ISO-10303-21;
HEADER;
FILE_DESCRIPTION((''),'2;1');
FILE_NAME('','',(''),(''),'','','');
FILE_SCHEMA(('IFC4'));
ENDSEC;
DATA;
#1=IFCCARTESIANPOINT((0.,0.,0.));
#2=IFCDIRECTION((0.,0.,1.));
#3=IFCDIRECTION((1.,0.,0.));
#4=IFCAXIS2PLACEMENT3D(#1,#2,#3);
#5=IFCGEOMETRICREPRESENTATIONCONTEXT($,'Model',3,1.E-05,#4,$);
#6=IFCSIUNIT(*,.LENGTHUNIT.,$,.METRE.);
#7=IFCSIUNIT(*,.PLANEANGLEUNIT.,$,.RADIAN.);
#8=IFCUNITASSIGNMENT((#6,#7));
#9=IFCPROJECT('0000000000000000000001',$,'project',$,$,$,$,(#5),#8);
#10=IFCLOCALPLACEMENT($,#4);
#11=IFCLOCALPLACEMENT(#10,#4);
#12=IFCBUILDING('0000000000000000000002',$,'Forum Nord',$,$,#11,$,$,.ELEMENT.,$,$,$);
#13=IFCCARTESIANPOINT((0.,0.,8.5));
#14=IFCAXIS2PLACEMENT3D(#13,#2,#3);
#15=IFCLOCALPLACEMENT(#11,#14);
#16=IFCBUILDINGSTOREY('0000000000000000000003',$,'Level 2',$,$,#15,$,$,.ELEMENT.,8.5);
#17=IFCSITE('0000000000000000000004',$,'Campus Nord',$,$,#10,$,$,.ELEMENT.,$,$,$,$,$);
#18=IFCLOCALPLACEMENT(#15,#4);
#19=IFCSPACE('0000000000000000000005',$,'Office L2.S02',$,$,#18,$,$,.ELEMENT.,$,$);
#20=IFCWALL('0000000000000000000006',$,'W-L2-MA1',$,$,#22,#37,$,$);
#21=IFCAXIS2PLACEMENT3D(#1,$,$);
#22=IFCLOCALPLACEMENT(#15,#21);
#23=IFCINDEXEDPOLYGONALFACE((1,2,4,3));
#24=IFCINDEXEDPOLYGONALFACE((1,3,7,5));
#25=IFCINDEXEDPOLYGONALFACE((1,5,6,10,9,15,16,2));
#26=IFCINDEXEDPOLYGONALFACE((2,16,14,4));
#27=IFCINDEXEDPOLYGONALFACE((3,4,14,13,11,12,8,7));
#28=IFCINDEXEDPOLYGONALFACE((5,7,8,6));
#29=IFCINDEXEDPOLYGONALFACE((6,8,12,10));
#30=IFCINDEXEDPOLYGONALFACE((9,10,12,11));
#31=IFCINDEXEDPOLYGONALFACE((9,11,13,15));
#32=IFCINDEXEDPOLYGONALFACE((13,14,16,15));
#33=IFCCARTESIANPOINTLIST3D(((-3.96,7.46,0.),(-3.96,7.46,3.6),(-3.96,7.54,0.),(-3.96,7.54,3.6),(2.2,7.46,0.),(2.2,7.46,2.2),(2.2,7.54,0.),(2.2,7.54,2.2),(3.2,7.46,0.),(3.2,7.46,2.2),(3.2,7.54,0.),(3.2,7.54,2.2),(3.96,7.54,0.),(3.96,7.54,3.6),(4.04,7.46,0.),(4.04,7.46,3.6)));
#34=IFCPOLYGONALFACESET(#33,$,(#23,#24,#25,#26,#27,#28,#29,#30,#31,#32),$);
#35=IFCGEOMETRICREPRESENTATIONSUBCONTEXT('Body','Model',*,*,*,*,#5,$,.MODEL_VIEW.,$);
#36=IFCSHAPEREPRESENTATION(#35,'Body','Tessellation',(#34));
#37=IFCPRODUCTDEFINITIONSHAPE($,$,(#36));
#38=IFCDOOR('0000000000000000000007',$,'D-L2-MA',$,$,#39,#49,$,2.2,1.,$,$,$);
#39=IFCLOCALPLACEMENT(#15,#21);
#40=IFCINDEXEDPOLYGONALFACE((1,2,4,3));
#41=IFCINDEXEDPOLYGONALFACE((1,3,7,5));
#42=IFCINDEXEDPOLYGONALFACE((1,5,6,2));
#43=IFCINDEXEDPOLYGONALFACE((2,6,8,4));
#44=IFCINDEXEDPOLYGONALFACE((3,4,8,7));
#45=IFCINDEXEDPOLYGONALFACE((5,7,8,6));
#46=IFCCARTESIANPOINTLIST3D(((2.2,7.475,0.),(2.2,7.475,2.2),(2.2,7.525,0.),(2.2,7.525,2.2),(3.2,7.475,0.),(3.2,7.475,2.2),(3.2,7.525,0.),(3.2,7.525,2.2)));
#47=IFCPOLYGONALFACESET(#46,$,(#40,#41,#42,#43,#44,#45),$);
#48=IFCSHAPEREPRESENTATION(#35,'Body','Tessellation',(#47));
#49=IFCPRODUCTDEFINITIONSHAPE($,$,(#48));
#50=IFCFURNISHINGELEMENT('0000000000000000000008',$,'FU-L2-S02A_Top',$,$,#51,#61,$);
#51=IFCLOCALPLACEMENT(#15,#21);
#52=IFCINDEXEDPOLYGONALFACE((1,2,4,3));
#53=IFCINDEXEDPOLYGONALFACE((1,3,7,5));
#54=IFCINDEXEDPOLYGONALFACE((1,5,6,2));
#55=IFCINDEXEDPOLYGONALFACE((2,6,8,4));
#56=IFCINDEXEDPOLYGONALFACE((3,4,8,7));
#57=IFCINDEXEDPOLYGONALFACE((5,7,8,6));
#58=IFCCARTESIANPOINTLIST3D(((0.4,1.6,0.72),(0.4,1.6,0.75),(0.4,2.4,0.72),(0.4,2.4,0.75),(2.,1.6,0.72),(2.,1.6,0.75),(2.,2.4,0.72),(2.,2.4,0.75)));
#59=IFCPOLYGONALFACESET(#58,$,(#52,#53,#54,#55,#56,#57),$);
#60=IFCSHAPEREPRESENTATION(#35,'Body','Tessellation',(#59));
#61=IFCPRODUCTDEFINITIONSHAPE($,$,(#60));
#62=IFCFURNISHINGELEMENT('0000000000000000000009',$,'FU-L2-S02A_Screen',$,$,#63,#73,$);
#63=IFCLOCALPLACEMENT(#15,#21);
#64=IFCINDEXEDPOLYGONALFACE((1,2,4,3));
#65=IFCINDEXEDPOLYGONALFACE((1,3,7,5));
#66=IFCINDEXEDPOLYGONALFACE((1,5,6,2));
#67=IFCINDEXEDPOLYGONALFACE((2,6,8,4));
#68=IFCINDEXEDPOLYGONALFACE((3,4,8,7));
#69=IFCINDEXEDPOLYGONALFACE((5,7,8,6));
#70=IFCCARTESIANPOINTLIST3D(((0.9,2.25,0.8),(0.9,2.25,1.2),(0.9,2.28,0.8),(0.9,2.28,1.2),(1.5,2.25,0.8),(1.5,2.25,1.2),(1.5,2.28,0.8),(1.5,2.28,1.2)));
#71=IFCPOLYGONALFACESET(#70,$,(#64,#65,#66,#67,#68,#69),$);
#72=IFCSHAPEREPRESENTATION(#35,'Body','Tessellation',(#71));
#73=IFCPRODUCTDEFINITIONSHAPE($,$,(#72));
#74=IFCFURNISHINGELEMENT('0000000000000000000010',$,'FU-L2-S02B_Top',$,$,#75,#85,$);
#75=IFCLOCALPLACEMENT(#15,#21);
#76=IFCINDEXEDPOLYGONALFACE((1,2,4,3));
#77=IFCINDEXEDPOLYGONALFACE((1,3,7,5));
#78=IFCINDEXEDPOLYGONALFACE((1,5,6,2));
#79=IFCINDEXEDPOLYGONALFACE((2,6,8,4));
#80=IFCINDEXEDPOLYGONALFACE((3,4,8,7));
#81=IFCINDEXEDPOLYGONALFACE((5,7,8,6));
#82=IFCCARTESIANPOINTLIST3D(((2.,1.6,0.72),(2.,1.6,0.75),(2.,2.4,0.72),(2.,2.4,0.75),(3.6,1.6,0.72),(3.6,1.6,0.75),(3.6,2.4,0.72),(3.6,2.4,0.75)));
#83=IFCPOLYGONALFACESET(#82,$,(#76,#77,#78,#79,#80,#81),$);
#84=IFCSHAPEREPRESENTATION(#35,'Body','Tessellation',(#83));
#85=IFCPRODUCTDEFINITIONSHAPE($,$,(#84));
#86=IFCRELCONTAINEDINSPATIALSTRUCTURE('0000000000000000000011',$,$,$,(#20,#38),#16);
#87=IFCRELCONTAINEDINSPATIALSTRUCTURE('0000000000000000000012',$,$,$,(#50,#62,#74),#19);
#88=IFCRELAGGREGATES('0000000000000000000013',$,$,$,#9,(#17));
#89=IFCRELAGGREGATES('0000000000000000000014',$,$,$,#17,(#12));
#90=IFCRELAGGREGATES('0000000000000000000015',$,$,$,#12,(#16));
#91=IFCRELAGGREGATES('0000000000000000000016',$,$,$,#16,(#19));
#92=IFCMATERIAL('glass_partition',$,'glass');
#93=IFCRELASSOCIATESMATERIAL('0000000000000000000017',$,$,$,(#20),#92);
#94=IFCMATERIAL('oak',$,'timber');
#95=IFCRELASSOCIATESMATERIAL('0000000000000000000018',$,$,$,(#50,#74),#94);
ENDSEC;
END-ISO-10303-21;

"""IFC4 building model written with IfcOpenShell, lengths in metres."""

from ifc_helpers import new_model, si_unit, frame, frame_2d, origin_with_axes, place, context, subcontext, project, spatial, polyline, rectangle, outline, extrude, material, element, fill, save


model = new_model("IFC4")

# Units and contexts
model_context = context("Model", 3, precision=1e-05, world=origin_with_axes())
body_context = subcontext(model_context, "Body", "Model", "MODEL_VIEW")
ifc_project = project(units=[si_unit("LENGTHUNIT", "METRE"), si_unit("PLANEANGLEUNIT", "RADIAN")], contexts=[model_context])

# Site, building, storey
site_placement = place(None, origin_with_axes())
site = spatial("IfcSite", under=ifc_project, at=site_placement, Name="Campus Nord", CompositionType="ELEMENT")
building_placement = place(site_placement, origin_with_axes())
building = spatial("IfcBuilding", under=site, at=building_placement, Name="Forum Nord", CompositionType="ELEMENT")
storey_placement = place(building_placement, frame((0.0, 0.0, 8.5), z_axis=(0.0, 0.0, 1.0), x_axis=(1.0, 0.0, 0.0)))
storey = spatial("IfcBuildingStorey", under=building, at=storey_placement, Name="Level 2", CompositionType="ELEMENT", Elevation=8.5)

# Wall, opening, door
ifc_material_1 = material(Name="glass_partition", Category="glass")
wall_1_placement = place(storey_placement, frame((-4.0, 7.5, 0.0), z_axis=(0.0, 0.0, 1.0), x_axis=(1.0, 0.0, 0.0)))
wall_1 = element("IfcWall", 1, at=wall_1_placement, inside=storey, material=ifc_material_1, Name="W-L2-MA1", context=body_context, shape_type="SweptSolid", body=[
    extrude(outline(polyline([(0.04, -0.04), (8.04, -0.04), (7.96, 0.04), (0.04, 0.04), (0.04, -0.04)])), origin_with_axes(), (0.0, 0.0, 1.0), 3.6),
])
opening_1_placement = place(storey_placement, frame((-4.0, 7.5, 0.0), z_axis=(0.0, 0.0, 1.0), x_axis=(1.0, 0.0, 0.0)))
opening_1 = element("IfcOpeningElement", 2, at=opening_1_placement, cuts=wall_1, context=body_context, shape_type="SweptSolid", body=[
    extrude(rectangle(XDim=1.0, YDim=0.08, at=frame_2d((6.7, 0.0), x_axis=(1.0, 0.0))), origin_with_axes(), (0.0, 0.0, 1.0), 2.2),
])
door_1_placement = place(storey_placement, frame((-4.0, 7.5, 0.0), z_axis=(0.0, 0.0, 1.0), x_axis=(1.0, 0.0, 0.0)))
door_1 = element("IfcDoor", 3, at=door_1_placement, inside=storey, Name="D-L2-MA", OverallHeight=2.2, OverallWidth=1.0, context=body_context, shape_type="SweptSolid", body=[
    extrude(rectangle(XDim=1.0, YDim=0.05, at=frame_2d((6.7, 0.0), x_axis=(1.0, 0.0))), origin_with_axes(), (0.0, 0.0, 1.0), 2.2),
])
fill(opening_1, door_1)

# Shared definitions
space_1_placement = place(storey_placement, origin_with_axes())
space_1 = spatial("IfcSpace", under=storey, at=space_1_placement, Name="Office L2.S02", CompositionType="ELEMENT")

# Furnishing elements
ifc_material_2 = material(Name="oak", Category="timber")
furnishing_1_placement = place(storey_placement, frame((0.4, 1.0, 0.0), z_axis=(0.0, 0.0, 1.0), x_axis=(1.0, 0.0, 0.0)))
element("IfcFurnishingElement", 4, at=furnishing_1_placement, inside=space_1, material=ifc_material_2, Name="FU-L2-S02A_Top", context=body_context, shape_type="SweptSolid", body=[
    extrude(rectangle(XDim=1.6, YDim=0.8, at=frame_2d((0.8, 1.0), x_axis=(1.0, 0.0))), frame((0.0, 0.0, 0.72), z_axis=(0.0, 0.0, 1.0), x_axis=(1.0, 0.0, 0.0)), (0.0, 0.0, 1.0), 0.03),
])
furnishing_2_placement = place(storey_placement, frame((0.4, 1.0, 0.0), z_axis=(0.0, 0.0, 1.0), x_axis=(1.0, 0.0, 0.0)))
element("IfcFurnishingElement", 5, at=furnishing_2_placement, inside=space_1, Name="FU-L2-S02A_Screen", context=body_context, shape_type="SweptSolid", body=[
    extrude(rectangle(XDim=0.6, YDim=0.03, at=frame_2d((0.8, 1.265), x_axis=(1.0, 0.0))), frame((0.0, 0.0, 0.8), z_axis=(0.0, 0.0, 1.0), x_axis=(1.0, 0.0, 0.0)), (0.0, 0.0, 1.0), 0.4),
])
furnishing_3_placement = place(storey_placement, frame((2.0, 1.0, 0.0), z_axis=(0.0, 0.0, 1.0), x_axis=(1.0, 0.0, 0.0)))
element("IfcFurnishingElement", 6, at=furnishing_3_placement, inside=space_1, material=ifc_material_2, Name="FU-L2-S02B_Top", context=body_context, shape_type="SweptSolid", body=[
    extrude(rectangle(XDim=1.6, YDim=0.8, at=frame_2d((0.8, 1.0), x_axis=(1.0, 0.0))), frame((0.0, 0.0, 0.72), z_axis=(0.0, 0.0, 1.0), x_axis=(1.0, 0.0, 0.0)), (0.0, 0.0, 1.0), 0.03),
])

save(model, "model.ifc")
